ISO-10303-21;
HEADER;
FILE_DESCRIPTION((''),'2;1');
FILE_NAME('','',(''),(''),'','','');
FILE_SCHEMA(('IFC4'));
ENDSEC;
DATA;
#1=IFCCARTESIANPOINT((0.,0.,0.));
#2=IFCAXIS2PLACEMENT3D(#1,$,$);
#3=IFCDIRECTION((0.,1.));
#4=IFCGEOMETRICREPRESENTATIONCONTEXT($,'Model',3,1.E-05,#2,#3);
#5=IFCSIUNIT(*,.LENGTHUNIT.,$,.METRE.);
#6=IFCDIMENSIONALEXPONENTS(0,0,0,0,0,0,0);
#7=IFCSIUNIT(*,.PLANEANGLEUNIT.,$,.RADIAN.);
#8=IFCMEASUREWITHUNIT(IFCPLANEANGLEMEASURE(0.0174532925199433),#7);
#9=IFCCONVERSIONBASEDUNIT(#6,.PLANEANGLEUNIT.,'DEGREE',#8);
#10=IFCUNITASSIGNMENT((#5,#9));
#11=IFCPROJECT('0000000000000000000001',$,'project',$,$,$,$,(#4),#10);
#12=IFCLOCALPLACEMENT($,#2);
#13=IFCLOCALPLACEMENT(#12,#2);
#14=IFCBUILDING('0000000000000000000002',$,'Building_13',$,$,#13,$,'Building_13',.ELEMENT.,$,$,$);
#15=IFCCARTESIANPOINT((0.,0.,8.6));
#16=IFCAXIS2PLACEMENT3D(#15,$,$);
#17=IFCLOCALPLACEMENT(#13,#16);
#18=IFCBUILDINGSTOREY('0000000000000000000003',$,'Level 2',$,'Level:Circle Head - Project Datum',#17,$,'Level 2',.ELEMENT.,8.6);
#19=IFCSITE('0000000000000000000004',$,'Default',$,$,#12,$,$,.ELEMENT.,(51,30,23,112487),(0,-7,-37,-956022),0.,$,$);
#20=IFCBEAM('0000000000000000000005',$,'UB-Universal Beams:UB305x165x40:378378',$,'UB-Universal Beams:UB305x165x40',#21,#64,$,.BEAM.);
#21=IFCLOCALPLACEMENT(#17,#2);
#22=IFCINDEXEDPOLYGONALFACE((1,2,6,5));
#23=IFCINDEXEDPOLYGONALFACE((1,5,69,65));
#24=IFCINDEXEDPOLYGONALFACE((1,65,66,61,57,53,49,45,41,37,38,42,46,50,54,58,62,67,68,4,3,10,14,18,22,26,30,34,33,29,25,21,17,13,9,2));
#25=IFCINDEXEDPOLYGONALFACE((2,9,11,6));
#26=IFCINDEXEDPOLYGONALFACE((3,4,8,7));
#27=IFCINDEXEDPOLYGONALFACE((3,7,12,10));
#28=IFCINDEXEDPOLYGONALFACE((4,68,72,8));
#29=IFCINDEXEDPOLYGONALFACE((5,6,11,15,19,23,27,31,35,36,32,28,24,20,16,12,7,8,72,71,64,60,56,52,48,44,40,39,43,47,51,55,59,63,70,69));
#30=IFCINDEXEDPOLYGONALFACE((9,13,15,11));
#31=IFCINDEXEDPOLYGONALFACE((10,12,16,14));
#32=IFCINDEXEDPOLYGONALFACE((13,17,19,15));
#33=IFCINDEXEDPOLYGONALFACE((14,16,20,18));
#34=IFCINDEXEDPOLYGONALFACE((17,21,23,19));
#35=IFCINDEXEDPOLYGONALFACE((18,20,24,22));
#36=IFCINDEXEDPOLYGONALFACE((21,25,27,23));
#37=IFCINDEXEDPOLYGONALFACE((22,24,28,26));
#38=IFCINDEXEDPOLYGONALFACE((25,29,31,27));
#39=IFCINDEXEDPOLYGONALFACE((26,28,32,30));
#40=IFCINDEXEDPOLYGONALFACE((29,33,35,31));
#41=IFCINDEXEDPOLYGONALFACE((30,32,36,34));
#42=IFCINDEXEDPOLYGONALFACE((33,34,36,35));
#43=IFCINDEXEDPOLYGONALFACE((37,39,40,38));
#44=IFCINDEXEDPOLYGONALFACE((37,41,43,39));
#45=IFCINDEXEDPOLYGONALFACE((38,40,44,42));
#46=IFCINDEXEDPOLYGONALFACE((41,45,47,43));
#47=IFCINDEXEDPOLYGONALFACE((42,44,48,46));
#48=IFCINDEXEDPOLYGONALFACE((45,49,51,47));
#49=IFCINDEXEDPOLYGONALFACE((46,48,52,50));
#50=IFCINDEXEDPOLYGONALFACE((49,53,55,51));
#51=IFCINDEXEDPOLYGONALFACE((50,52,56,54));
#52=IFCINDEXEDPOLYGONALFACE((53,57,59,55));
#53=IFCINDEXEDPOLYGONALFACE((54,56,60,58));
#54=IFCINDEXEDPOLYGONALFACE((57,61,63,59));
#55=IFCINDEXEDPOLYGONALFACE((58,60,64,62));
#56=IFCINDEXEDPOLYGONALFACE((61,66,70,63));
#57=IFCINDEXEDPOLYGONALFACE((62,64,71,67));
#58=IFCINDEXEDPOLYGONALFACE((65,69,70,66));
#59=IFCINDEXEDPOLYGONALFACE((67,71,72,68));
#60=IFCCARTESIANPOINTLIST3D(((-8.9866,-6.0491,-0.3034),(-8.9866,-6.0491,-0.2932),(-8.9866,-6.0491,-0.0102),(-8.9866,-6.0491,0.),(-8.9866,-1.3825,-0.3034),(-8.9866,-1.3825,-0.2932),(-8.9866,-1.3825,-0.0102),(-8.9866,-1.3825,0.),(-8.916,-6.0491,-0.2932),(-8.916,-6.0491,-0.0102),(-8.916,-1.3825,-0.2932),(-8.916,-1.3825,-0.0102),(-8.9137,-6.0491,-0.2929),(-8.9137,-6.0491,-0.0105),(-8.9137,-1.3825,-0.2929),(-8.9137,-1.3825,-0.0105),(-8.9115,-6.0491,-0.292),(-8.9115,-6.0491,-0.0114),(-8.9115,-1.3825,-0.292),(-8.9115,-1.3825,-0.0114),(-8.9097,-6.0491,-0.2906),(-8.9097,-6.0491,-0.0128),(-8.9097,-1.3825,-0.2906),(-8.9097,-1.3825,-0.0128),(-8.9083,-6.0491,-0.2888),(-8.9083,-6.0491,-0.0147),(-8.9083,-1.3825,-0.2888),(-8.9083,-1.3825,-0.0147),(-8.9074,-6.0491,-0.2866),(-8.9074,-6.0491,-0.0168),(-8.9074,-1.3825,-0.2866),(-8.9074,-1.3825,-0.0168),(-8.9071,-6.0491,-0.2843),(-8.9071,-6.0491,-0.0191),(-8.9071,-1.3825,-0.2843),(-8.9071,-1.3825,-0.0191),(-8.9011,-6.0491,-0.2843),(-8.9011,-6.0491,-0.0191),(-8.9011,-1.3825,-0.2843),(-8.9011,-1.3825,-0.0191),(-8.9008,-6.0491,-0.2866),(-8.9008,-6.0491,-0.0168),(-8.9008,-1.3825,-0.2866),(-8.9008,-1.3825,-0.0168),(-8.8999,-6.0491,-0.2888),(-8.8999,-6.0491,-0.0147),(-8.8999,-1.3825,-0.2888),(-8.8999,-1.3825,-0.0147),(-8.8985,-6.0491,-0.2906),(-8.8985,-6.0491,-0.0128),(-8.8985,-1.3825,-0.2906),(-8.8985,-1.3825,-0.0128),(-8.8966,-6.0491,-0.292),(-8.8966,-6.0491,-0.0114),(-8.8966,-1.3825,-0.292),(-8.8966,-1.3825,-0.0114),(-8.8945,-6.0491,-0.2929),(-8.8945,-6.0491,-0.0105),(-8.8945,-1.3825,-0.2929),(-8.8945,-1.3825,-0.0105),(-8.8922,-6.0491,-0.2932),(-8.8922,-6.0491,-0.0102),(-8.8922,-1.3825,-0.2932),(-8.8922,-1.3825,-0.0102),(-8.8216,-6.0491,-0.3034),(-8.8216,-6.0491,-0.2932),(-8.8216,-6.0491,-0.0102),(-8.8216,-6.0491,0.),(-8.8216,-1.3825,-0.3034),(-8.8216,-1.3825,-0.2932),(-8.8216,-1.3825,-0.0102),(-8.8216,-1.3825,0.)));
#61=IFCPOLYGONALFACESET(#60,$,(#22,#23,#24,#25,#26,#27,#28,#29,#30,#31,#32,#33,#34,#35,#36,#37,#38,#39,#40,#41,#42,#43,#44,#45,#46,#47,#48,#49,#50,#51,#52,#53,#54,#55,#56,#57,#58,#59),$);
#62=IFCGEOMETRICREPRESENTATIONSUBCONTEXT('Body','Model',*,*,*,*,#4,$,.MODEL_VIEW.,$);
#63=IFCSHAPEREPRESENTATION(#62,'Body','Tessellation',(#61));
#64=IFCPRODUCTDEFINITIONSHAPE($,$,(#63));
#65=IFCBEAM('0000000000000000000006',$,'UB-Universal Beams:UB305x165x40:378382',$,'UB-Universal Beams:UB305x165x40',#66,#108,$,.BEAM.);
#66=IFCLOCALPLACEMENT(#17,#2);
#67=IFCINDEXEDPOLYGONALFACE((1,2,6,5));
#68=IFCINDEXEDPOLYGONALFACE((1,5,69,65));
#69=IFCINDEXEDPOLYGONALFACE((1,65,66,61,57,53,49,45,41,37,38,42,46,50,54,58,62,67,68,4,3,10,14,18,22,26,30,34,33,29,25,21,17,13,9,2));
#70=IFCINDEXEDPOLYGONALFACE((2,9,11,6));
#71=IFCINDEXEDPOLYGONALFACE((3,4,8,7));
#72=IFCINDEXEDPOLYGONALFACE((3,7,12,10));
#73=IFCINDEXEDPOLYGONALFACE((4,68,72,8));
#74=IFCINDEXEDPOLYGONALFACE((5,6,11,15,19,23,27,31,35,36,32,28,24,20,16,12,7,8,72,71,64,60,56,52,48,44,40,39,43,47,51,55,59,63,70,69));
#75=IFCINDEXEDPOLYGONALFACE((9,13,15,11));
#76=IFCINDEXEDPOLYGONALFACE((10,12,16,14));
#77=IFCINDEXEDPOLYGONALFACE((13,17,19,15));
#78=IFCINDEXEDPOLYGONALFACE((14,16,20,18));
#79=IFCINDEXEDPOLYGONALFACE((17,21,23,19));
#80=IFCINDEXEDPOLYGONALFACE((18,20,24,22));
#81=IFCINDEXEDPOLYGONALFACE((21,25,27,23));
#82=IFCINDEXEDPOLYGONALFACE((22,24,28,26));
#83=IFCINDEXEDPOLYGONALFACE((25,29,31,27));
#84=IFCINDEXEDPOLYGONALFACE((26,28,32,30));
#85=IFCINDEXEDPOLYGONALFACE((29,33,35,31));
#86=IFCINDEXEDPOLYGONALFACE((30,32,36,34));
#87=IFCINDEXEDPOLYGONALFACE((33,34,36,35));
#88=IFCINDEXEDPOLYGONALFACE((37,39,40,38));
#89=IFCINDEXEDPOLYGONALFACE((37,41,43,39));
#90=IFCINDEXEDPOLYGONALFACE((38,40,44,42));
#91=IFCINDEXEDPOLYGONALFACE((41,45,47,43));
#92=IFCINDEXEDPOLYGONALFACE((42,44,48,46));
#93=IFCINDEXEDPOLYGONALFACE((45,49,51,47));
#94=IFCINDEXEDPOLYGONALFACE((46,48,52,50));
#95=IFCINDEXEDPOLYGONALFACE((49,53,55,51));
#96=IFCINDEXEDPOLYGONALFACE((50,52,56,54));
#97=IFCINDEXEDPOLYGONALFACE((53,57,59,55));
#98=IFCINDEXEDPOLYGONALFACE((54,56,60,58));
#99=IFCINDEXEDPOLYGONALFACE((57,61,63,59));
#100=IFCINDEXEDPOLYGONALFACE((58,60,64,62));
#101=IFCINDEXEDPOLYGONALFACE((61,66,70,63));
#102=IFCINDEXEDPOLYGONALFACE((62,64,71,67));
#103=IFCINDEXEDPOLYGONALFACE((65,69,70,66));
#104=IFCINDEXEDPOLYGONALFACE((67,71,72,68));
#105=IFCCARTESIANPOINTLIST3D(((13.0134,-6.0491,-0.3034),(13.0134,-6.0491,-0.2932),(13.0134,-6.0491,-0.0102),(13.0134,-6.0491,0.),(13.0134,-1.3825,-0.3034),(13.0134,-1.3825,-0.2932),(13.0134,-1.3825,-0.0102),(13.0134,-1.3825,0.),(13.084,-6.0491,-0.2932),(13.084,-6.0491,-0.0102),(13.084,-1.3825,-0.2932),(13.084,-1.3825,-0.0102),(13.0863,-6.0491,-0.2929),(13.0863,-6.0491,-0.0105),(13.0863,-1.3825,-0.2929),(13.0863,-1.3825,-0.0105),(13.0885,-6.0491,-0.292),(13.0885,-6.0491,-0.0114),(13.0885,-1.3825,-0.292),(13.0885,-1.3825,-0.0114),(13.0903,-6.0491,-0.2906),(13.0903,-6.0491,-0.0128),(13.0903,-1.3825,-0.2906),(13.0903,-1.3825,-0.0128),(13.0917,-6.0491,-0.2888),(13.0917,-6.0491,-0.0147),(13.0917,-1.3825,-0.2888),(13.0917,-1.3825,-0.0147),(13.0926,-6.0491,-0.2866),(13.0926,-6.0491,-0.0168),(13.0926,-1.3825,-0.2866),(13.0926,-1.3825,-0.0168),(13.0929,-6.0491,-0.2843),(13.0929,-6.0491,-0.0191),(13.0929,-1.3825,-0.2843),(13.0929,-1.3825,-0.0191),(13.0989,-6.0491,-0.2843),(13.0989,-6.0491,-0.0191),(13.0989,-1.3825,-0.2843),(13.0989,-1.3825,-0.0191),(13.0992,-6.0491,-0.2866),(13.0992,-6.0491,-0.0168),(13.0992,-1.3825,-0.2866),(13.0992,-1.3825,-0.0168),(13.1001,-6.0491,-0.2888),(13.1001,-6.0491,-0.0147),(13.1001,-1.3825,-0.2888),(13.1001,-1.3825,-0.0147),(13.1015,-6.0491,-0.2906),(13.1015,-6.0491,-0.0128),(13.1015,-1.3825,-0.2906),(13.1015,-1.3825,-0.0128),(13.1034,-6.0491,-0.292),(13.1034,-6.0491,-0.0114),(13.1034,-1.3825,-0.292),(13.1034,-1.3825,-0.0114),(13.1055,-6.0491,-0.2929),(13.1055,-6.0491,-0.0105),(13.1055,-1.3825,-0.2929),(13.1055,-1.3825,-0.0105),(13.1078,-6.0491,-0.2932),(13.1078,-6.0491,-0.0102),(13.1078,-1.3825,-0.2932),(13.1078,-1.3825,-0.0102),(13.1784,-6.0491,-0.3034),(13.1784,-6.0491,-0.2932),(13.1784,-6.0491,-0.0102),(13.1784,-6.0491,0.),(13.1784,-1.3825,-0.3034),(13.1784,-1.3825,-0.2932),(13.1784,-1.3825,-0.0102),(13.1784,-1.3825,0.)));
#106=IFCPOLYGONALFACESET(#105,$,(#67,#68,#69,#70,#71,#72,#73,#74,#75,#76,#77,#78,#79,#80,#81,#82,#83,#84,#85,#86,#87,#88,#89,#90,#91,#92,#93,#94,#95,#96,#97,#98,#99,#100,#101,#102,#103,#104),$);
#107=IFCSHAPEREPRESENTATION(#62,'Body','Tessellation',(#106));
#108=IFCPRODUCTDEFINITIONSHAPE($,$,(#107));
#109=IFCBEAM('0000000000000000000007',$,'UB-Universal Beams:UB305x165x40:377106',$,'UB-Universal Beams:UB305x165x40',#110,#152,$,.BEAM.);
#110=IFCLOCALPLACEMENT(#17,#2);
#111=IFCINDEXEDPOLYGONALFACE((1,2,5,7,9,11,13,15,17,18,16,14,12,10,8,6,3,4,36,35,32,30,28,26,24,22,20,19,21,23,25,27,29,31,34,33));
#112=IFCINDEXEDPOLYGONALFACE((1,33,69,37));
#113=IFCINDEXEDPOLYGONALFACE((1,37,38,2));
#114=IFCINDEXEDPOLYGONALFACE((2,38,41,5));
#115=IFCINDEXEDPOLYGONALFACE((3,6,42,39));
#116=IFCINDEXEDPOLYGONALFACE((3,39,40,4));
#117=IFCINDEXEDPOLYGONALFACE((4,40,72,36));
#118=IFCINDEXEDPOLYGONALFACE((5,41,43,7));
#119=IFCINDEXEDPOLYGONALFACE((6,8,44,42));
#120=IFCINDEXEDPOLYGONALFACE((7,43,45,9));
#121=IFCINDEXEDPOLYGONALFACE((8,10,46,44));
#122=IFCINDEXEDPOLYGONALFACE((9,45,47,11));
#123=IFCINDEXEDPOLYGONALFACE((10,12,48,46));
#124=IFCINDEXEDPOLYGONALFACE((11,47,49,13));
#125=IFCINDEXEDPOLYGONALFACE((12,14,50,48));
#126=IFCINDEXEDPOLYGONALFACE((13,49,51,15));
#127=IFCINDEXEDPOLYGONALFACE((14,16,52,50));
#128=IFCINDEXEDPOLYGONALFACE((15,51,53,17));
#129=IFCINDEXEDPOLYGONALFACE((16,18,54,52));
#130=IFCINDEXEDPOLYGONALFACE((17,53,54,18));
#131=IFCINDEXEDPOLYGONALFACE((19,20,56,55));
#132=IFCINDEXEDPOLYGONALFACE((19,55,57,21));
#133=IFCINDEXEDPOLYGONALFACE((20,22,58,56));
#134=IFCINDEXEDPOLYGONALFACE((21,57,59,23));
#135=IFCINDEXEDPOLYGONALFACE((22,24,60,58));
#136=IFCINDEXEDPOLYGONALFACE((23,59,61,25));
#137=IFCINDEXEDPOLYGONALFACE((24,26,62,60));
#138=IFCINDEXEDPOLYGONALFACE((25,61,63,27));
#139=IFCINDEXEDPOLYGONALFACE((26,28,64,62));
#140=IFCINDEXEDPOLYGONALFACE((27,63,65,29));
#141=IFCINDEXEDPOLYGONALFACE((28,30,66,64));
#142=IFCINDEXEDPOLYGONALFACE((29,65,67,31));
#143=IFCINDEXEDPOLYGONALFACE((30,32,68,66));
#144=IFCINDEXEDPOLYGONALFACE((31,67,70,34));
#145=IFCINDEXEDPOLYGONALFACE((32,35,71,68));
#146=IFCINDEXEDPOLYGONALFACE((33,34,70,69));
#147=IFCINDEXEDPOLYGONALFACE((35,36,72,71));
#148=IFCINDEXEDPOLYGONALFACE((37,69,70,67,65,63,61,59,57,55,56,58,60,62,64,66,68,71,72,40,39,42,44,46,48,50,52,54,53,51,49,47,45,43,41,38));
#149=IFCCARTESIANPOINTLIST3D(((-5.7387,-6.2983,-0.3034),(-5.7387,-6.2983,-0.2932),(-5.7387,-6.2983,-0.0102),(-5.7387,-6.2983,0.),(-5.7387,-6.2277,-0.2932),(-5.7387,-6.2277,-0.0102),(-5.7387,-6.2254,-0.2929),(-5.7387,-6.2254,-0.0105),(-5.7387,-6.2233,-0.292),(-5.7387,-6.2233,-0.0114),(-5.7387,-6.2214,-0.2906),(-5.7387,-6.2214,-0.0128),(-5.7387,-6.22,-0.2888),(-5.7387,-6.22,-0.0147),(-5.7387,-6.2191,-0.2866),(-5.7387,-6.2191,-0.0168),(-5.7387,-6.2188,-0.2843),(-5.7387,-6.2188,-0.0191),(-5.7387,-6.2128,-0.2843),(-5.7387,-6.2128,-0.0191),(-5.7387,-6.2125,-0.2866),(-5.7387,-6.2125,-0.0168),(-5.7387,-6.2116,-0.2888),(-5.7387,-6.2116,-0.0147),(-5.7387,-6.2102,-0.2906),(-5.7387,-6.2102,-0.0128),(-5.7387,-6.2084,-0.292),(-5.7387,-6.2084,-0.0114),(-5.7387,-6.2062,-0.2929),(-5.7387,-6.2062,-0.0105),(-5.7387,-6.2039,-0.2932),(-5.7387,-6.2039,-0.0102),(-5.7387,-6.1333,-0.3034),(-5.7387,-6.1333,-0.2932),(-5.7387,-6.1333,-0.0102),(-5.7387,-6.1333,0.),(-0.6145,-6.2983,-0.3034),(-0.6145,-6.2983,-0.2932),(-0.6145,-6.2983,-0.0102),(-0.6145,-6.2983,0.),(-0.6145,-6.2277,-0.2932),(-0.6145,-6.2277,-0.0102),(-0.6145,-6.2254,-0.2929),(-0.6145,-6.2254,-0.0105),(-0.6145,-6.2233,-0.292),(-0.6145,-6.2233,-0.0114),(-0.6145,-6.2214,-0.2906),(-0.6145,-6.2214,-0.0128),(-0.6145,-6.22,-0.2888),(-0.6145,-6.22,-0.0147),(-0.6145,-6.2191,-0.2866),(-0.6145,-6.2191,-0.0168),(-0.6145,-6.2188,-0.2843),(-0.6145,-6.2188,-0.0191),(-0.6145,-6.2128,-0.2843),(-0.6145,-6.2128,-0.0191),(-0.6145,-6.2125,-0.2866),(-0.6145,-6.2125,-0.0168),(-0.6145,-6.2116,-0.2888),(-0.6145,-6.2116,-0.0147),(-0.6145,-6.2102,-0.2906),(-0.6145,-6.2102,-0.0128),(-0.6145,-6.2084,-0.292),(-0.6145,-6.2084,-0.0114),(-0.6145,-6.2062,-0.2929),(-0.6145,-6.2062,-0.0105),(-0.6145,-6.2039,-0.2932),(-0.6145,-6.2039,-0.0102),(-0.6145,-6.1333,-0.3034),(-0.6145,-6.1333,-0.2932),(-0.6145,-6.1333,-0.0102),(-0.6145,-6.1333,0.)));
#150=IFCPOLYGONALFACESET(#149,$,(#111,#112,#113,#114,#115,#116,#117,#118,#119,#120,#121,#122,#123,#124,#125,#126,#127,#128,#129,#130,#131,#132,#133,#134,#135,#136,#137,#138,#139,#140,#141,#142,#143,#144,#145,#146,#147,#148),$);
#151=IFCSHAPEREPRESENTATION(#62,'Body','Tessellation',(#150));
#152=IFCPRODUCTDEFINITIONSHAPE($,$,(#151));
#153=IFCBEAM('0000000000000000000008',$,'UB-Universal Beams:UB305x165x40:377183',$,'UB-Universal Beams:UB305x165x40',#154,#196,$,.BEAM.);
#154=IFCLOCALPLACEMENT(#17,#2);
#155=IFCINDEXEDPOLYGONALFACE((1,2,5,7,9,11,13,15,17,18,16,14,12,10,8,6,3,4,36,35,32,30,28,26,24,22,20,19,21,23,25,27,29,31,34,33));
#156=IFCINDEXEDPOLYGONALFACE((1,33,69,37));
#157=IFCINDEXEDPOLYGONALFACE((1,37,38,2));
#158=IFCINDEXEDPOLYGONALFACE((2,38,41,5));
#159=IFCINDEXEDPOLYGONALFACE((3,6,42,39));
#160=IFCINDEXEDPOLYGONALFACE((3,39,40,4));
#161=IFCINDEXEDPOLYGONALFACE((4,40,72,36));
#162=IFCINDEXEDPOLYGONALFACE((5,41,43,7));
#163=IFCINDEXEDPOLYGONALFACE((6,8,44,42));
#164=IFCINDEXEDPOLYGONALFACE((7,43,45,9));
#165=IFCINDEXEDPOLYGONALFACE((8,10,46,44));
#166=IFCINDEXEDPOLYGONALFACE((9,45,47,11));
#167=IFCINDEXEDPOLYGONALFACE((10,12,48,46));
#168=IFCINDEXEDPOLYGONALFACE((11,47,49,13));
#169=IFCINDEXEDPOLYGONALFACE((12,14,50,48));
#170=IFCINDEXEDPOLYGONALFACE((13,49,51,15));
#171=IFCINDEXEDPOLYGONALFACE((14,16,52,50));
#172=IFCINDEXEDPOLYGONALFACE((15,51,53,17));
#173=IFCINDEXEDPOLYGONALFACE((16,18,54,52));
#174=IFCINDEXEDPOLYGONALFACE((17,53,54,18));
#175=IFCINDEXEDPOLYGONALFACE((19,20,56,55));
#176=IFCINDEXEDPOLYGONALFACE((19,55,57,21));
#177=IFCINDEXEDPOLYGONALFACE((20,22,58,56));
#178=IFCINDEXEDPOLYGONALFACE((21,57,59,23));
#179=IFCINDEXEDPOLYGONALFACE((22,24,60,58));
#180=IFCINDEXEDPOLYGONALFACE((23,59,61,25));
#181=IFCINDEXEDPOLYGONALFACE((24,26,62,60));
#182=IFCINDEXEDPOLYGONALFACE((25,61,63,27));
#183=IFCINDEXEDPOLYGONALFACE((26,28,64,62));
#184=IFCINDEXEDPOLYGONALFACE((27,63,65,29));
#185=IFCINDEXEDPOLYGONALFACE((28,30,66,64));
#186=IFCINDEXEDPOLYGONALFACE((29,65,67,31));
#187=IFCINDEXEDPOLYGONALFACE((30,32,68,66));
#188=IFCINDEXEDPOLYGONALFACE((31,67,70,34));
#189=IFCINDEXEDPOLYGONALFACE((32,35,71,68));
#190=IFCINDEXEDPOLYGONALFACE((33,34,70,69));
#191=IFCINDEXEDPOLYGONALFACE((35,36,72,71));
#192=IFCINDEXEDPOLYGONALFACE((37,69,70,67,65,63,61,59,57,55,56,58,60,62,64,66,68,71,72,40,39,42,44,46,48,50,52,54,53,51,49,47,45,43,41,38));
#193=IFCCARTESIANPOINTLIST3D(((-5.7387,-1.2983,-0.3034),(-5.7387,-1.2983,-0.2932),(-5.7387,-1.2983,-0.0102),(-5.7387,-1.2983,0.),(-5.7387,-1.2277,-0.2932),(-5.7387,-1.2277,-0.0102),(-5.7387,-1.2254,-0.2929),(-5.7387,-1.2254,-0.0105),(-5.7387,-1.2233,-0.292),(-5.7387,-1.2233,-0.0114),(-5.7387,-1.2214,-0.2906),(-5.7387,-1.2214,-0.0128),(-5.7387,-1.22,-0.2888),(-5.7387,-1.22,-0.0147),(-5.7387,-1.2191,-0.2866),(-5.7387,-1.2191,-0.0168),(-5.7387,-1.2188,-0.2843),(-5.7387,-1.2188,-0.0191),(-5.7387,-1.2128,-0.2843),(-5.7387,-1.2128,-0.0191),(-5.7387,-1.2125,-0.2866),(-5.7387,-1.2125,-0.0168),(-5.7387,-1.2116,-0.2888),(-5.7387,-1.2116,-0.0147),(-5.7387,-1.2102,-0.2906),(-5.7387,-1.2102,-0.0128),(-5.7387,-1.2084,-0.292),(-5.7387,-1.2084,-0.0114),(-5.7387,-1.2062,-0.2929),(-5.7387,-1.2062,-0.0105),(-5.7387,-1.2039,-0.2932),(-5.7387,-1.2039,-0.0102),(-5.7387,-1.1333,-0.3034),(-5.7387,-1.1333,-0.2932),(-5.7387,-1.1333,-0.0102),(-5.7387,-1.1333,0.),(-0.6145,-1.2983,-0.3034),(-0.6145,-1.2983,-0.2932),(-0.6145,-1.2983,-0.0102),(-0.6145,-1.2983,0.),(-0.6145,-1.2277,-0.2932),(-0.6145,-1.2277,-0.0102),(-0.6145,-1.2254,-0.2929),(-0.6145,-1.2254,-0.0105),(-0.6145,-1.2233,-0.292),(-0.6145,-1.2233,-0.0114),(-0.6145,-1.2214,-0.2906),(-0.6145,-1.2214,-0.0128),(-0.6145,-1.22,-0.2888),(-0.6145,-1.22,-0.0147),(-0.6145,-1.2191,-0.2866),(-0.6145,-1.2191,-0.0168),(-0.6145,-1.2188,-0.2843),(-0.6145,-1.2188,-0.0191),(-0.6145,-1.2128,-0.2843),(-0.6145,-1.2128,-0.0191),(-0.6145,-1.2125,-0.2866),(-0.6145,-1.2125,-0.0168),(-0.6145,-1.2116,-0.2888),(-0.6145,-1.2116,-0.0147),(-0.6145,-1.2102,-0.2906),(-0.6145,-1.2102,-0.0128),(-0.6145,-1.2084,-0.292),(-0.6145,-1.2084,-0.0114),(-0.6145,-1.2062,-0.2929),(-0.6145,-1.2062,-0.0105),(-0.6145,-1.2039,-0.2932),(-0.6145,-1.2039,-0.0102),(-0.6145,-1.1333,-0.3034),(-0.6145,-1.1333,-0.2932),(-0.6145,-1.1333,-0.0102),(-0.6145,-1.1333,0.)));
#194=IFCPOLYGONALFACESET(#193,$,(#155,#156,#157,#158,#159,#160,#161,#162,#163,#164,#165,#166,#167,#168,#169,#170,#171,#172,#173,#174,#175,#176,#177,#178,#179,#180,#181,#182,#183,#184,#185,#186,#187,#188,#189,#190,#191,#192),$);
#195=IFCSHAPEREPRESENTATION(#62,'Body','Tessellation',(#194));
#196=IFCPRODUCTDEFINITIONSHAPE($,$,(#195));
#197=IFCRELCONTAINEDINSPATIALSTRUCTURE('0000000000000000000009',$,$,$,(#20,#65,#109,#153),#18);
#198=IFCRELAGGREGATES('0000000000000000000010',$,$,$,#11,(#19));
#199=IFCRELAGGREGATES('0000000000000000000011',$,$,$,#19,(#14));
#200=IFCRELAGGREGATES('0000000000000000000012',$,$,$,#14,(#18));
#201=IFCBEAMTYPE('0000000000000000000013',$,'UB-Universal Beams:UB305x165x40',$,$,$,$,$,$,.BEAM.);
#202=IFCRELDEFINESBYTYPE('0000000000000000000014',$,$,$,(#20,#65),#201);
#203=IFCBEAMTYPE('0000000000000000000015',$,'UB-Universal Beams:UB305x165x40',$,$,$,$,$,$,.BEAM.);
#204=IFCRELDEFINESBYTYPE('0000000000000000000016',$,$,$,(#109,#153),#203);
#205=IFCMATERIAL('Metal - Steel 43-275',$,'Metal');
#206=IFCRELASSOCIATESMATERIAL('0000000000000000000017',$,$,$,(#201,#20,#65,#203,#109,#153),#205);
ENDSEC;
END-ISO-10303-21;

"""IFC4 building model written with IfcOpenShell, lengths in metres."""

from ifc_helpers import new_model, entity, si_unit, converted_unit, direction, frame, origin, place, context, subcontext, project, spatial, line, arc, indexed_curve, outline, extrude, source, transform, mapped, material, type_object, type_shapes, element, save


model = new_model("IFC4")

# Units and contexts
model_context = context("Model", 3, precision=1e-05, world=origin(), true_north=direction((0.0, 1.0)))
body_context = subcontext(model_context, "Body", "Model", "MODEL_VIEW")
ifc_project = project(units=[si_unit("LENGTHUNIT", "METRE"), converted_unit("PLANEANGLEUNIT", "DEGREE", entity("IfcPlaneAngleMeasure", 0.0174532925199433), si_unit("PLANEANGLEUNIT", "RADIAN"), dimensions=[0, 0, 0, 0, 0, 0, 0])], contexts=[model_context])

# Site, building, storey
site_placement = place(None, origin())
site = spatial("IfcSite", under=ifc_project, at=site_placement, Name="Default", CompositionType="ELEMENT", RefLatitude=(51, 30, 23, 112487), RefLongitude=(0, -7, -37, -956022), RefElevation=0.0)
building_placement = place(site_placement, origin())
building = spatial("IfcBuilding", under=site, at=building_placement, Name="Building_13", LongName="Building_13", CompositionType="ELEMENT")
storey_placement = place(building_placement, frame((0.0, 0.0, 8.6)))
storey = spatial("IfcBuildingStorey", under=building, at=storey_placement, Name="Level 2", ObjectType="Level:Circle Head - Project Datum", LongName="Level 2", CompositionType="ELEMENT", Elevation=8.6)

# Beams
ifc_material_1 = material(Name="Metal - Steel 43-275", Category="Metal")
beam_type_1 = type_object("IfcBeamType", Name="UB-Universal Beams:UB305x165x40", PredefinedType="BEAM", material=ifc_material_1)
shared_shape_1 = source(origin(), body_context, "Body", "SweptSolid", [
    extrude(outline(indexed_curve([(-0.0825, -0.1415), (-0.0825, -0.1517), (0.0825, -0.1517), (0.0825, -0.1415), (0.0119, -0.1415), (0.0056, -0.1389), (0.003, -0.1326), (0.003, 0.1326), (0.0056, 0.1389), (0.0119, 0.1415), (0.0825, 0.1415), (0.0825, 0.1517), (-0.0825, 0.1517), (-0.0825, 0.1415), (-0.0119, 0.1415), (-0.0056, 0.1389), (-0.003, 0.1326), (-0.003, -0.1326), (-0.0056, -0.1389), (-0.0119, -0.1415)], segments=[line(1, 2, 3, 4, 5), arc(5, 6, 7), line(7, 8), arc(8, 9, 10), line(10, 11, 12, 13, 14, 15), arc(15, 16, 17), line(17, 18), arc(18, 19, 20), line(20, 1)], self_intersect=False)), frame((-2.3333, 0.0, 0.0), z_axis=(-1.0, 0.0, 0.0), x_axis=(0.0, -1.0, 0.0)), (0.0, 0.0, -1.0), 4.6666),
])
type_shapes(beam_type_1, [shared_shape_1])
for number, where, z_axis, x_axis, name in (
    (1, (-8.9041, -3.7158, -0.1517), (0.0, 0.0, 1.0), (0.0, -1.0, 0.0), "UB-Universal Beams:UB305x165x40:378378"),
    (2, (13.0959, -3.7158, -0.1517), (0.0, 0.0, 1.0), (0.0, -1.0, 0.0), "UB-Universal Beams:UB305x165x40:378382"),
):
    element("IfcBeam", number, at=place(storey_placement, frame(where, z_axis=z_axis, x_axis=x_axis)), inside=storey, type_object=beam_type_1, material=ifc_material_1, Name=name, ObjectType="UB-Universal Beams:UB305x165x40", PredefinedType="BEAM", context=body_context, shape_type="MappedRepresentation", body=[
        mapped(shared_shape_1, transform((0.0, 0.0, 0.0), scale=1.0)),
    ])
beam_type_2 = type_object("IfcBeamType", Name="UB-Universal Beams:UB305x165x40", PredefinedType="BEAM", material=ifc_material_1)
shared_shape_2 = source(origin(), body_context, "Body", "SweptSolid", [
    extrude(outline(indexed_curve([(-0.0825, -0.1415), (-0.0825, -0.1517), (0.0825, -0.1517), (0.0825, -0.1415), (0.0119, -0.1415), (0.0056, -0.1389), (0.003, -0.1326), (0.003, 0.1326), (0.0056, 0.1389), (0.0119, 0.1415), (0.0825, 0.1415), (0.0825, 0.1517), (-0.0825, 0.1517), (-0.0825, 0.1415), (-0.0119, 0.1415), (-0.0056, 0.1389), (-0.003, 0.1326), (-0.003, -0.1326), (-0.0056, -0.1389), (-0.0119, -0.1415)], segments=[line(1, 2, 3, 4, 5), arc(5, 6, 7), line(7, 8), arc(8, 9, 10), line(10, 11, 12, 13, 14, 15), arc(15, 16, 17), line(17, 18), arc(18, 19, 20), line(20, 1)], self_intersect=False)), frame((-2.5621, 0.0, 0.0), z_axis=(-1.0, 0.0, 0.0), x_axis=(0.0, -1.0, 0.0)), (0.0, 0.0, -1.0), 5.1242),
])
type_shapes(beam_type_2, [shared_shape_2])
for number, where, name in (
    (3, (-3.1766, -6.2158, -0.1517), "UB-Universal Beams:UB305x165x40:377106"),
    (4, (-3.1766, -1.2158, -0.1517), "UB-Universal Beams:UB305x165x40:377183"),
):
    element("IfcBeam", number, at=place(storey_placement, frame(where)), inside=storey, type_object=beam_type_2, material=ifc_material_1, Name=name, ObjectType="UB-Universal Beams:UB305x165x40", PredefinedType="BEAM", context=body_context, shape_type="MappedRepresentation", body=[
        mapped(shared_shape_2, transform((0.0, 0.0, 0.0), scale=1.0)),
    ])

save(model, "model.ifc")
